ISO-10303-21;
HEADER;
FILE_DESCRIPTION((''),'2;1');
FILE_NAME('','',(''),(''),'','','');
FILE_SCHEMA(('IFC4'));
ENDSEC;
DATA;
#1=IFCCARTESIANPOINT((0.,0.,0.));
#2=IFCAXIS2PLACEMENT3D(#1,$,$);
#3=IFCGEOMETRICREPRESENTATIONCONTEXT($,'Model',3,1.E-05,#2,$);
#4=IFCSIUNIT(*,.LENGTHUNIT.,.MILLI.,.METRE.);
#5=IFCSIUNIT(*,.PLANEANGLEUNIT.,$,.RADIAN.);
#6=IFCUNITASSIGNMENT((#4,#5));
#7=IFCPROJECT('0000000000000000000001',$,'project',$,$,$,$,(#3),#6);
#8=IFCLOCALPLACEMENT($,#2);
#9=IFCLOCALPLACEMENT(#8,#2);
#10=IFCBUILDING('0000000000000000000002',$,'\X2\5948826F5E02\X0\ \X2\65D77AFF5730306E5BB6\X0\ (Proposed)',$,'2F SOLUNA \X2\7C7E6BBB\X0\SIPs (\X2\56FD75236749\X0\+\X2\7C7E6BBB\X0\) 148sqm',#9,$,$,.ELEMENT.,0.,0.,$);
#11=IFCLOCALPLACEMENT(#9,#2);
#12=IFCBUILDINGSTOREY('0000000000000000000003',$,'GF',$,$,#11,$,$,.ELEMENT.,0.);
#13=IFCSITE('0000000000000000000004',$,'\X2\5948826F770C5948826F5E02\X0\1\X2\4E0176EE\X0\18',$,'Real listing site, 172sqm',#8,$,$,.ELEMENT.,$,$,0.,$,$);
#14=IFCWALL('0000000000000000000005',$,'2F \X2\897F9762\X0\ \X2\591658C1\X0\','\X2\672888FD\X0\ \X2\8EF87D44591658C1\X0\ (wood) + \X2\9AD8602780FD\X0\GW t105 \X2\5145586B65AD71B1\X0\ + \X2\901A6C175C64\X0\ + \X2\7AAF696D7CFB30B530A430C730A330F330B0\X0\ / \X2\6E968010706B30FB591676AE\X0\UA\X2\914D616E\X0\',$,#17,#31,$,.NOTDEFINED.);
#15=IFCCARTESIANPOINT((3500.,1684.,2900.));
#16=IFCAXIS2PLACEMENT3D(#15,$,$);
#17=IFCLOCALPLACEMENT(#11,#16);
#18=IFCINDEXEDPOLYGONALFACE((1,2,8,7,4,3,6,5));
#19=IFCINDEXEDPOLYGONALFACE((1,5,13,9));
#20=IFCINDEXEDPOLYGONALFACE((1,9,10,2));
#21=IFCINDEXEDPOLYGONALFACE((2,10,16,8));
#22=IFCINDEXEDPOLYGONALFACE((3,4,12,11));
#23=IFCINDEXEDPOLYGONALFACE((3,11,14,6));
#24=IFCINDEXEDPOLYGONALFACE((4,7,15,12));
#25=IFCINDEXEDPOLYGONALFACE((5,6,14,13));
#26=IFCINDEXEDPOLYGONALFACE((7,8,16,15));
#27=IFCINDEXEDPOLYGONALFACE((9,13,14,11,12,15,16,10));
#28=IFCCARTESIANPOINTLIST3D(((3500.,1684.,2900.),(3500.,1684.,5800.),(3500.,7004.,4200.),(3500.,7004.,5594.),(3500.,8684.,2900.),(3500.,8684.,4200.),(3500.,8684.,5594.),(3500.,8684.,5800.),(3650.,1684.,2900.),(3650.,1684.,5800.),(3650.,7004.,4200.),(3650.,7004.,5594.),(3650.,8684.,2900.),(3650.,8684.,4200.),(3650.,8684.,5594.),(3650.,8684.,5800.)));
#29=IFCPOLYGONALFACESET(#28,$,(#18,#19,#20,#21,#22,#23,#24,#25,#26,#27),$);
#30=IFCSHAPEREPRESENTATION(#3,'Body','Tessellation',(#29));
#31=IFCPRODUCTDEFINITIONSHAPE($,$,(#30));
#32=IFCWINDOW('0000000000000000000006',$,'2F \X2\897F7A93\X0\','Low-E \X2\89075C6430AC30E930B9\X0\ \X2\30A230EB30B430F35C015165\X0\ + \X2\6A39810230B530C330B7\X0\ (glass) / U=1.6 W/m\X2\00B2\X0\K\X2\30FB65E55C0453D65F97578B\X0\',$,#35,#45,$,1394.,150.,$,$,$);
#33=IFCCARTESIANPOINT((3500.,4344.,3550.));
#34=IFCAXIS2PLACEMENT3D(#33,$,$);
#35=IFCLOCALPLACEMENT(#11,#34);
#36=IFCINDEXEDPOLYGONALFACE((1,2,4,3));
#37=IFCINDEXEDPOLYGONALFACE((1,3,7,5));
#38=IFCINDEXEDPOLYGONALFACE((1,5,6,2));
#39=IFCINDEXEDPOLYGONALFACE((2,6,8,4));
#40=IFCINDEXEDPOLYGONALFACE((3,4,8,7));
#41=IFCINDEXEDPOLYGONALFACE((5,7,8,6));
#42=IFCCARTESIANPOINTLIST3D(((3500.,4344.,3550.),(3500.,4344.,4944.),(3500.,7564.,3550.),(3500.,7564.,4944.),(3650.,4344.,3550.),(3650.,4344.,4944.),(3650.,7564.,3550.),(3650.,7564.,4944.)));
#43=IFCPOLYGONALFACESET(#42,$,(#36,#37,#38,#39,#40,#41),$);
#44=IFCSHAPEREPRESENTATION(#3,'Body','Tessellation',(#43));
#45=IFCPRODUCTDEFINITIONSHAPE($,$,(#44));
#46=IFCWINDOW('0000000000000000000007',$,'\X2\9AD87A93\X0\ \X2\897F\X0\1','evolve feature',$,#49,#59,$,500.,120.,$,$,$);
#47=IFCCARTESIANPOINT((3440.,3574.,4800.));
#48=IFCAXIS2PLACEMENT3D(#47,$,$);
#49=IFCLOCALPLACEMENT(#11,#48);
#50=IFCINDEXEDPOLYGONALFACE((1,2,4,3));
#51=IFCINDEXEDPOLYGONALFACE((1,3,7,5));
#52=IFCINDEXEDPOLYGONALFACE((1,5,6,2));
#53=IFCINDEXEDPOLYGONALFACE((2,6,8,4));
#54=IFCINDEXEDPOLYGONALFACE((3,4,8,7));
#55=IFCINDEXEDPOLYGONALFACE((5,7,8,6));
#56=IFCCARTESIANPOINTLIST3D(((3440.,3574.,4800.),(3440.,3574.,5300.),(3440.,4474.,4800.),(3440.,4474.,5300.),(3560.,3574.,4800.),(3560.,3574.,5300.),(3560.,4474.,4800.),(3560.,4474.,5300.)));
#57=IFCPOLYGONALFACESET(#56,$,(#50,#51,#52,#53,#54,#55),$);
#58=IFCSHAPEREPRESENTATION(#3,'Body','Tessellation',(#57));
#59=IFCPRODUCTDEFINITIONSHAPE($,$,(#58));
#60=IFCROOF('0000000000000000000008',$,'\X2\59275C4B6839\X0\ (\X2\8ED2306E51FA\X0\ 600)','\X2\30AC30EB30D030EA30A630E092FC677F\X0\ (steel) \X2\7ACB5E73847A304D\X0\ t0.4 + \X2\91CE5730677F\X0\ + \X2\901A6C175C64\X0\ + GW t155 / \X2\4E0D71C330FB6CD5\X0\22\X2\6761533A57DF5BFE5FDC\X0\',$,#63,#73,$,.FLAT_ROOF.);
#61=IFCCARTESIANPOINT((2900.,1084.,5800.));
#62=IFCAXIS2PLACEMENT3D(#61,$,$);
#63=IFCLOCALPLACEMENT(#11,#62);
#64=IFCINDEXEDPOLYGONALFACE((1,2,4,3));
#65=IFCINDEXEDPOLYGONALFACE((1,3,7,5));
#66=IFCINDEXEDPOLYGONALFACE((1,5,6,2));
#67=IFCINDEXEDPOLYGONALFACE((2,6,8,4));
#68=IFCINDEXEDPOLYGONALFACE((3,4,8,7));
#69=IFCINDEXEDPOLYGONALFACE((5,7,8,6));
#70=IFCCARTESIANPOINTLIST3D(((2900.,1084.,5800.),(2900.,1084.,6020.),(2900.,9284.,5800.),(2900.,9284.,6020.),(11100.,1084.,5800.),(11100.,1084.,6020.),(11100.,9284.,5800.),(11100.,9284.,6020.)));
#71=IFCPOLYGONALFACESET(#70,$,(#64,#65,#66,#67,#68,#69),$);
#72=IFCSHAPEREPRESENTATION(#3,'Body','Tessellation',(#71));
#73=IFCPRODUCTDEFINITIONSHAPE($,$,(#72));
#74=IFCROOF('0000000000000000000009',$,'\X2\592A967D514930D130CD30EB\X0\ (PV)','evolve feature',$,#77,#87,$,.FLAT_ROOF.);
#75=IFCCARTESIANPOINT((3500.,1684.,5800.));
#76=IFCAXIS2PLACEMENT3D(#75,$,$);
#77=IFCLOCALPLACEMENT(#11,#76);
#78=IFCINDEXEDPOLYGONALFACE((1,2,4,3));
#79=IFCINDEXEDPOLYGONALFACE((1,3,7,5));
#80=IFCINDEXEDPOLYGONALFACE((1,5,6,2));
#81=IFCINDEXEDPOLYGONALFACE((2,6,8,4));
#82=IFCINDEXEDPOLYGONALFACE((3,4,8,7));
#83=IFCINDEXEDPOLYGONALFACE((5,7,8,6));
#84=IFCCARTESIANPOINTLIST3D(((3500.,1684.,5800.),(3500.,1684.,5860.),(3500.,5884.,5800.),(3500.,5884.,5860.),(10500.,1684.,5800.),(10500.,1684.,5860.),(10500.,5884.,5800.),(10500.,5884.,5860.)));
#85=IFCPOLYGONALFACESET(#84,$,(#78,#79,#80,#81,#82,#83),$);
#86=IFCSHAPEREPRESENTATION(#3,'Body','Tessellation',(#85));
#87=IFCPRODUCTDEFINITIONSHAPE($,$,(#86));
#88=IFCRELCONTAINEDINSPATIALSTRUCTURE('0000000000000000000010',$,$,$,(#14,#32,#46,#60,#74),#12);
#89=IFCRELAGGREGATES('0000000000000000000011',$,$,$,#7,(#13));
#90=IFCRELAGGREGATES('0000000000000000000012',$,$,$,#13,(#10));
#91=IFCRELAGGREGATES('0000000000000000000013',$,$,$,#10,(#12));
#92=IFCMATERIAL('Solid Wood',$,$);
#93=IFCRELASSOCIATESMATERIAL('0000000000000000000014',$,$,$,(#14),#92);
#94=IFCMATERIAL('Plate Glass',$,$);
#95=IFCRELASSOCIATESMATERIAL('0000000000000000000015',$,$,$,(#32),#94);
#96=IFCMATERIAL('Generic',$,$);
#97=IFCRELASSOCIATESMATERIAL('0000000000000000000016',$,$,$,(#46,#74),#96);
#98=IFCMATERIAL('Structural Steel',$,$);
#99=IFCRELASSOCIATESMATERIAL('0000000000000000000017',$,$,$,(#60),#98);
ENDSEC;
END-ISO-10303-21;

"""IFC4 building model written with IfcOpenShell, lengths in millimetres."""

from ifc_helpers import new_model, si_unit, frame, frame_2d, origin, place, context, project, spatial, rectangle, extrude, material, element, fill, save


model = new_model("IFC4")

# Units and contexts
model_context = context("Model", 3, precision=1e-05, world=origin())
ifc_project = project(units=[si_unit("LENGTHUNIT", "METRE", prefix="MILLI"), si_unit("PLANEANGLEUNIT", "RADIAN")], contexts=[model_context])

# Site, building, storey
site_placement = place(None, origin())
site = spatial("IfcSite", under=ifc_project, at=site_placement, Name="奈良県奈良市1丁目18", ObjectType="Real listing site, 172sqm", CompositionType="ELEMENT", RefElevation=0.0)
building_placement = place(site_placement, origin())
building = spatial("IfcBuilding", under=site, at=building_placement, Name="奈良市 旗竿地の家 (Proposed)", ObjectType="2F SOLUNA 籾殻SIPs (国産杉+籾殻) 148sqm", CompositionType="ELEMENT", ElevationOfRefHeight=0.0, ElevationOfTerrain=0.0)
storey_placement = place(building_placement, origin())
storey = spatial("IfcBuildingStorey", under=building, at=storey_placement, Name="GF", CompositionType="ELEMENT", Elevation=0.0)

# Shared definitions
ifc_material_1 = material(Name="Solid Wood")
ifc_material_2 = material(Name="Generic")

# Shared definitions
ifc_material_3 = material(Name="Plate Glass")

# Wall, openings, windows
wall_1_placement = place(storey_placement, frame((3500.0, 1684.0, 2900.0)))
wall_1 = element("IfcWall", 1, at=wall_1_placement, inside=storey, material=ifc_material_1, Name="2F 西面 外壁", Description="木製 軸組外壁 (wood) + 高性能GW t105 充填断熱 + 通気層 + 窯業系サイディング / 準耐火・外皮UA配慮", PredefinedType="NOTDEFINED", context=model_context, shape_type="SweptSolid", body=[
    extrude(rectangle(XDim=150.0, YDim=7000.0, at=frame_2d((75.0, 3500.0))), frame((3500.0, 1684.0, 2900.0)), (0.0, 0.0, 1.0), 2900.0),
])
opening_1_placement = place(storey_placement, frame((3500.0, 4344.0, 3550.0)))
opening_1 = element("IfcOpeningElement", 2, at=opening_1_placement, cuts=wall_1, PredefinedType="NOTDEFINED", context=model_context, shape_type="SweptSolid", body=[
    extrude(rectangle(XDim=150.0, YDim=3220.0, at=frame_2d((75.0, 1610.0))), frame((3500.0, 4344.0, 3550.0)), (0.0, 0.0, 1.0), 1394.0),
])
opening_2_placement = place(storey_placement, frame((3440.0, 3574.0, 4800.0)))
opening_2 = element("IfcOpeningElement", 3, at=opening_2_placement, cuts=wall_1, PredefinedType="NOTDEFINED", context=model_context, shape_type="SweptSolid", body=[
    extrude(rectangle(XDim=120.0, YDim=900.0, at=frame_2d((60.0, 450.0))), frame((3440.0, 3574.0, 4800.0)), (0.0, 0.0, 1.0), 500.0),
])
window_1_placement = place(storey_placement, frame((3500.0, 4344.0, 3550.0)))
window_1 = element("IfcWindow", 4, at=window_1_placement, inside=storey, material=ifc_material_3, Name="2F 西窓", Description="Low-E 複層ガラス アルゴン封入 + 樹脂サッシ (glass) / U=1.6 W/m²K・日射取得型", OverallHeight=1394.0, OverallWidth=150.0, context=model_context, shape_type="SweptSolid", body=[
    extrude(rectangle(XDim=150.0, YDim=3220.0, at=frame_2d((75.0, 1610.0))), frame((3500.0, 4344.0, 3550.0)), (0.0, 0.0, 1.0), 1394.0),
])
fill(opening_1, window_1)
window_2_placement = place(storey_placement, frame((3440.0, 3574.0, 4800.0)))
window_2 = element("IfcWindow", 5, at=window_2_placement, inside=storey, material=ifc_material_2, Name="高窓 西1", Description="evolve feature", OverallHeight=500.0, OverallWidth=120.0, context=model_context, shape_type="SweptSolid", body=[
    extrude(rectangle(XDim=120.0, YDim=900.0, at=frame_2d((60.0, 450.0))), frame((3440.0, 3574.0, 4800.0)), (0.0, 0.0, 1.0), 500.0),
])
fill(opening_2, window_2)

# Roofs
ifc_material_4 = material(Name="Structural Steel")
roof_1_placement = place(storey_placement, frame((2900.0, 1084.0, 5800.0)))
element("IfcRoof", 6, at=roof_1_placement, inside=storey, material=ifc_material_4, Name="大屋根 (軒の出 600)", Description="ガルバリウム鋼板 (steel) 立平葺き t0.4 + 野地板 + 通気層 + GW t155 / 不燃・法22条区域対応", PredefinedType="FLAT_ROOF", context=model_context, shape_type="SweptSolid", body=[
    extrude(rectangle(XDim=8200.0, YDim=8200.0, at=frame_2d((4100.0, 4100.0))), frame((2900.0, 1084.0, 5800.0)), (0.0, 0.0, 1.0), 220.0),
])
roof_2_placement = place(storey_placement, frame((3500.0, 1684.0, 5800.0)))
element("IfcRoof", 7, at=roof_2_placement, inside=storey, material=ifc_material_2, Name="太陽光パネル (PV)", Description="evolve feature", PredefinedType="FLAT_ROOF", context=model_context, shape_type="SweptSolid", body=[
    extrude(rectangle(XDim=7000.0, YDim=4200.0, at=frame_2d((3500.0, 2100.0))), frame((3500.0, 1684.0, 5800.0)), (0.0, 0.0, 1.0), 60.0),
])

save(model, "model.ifc")
